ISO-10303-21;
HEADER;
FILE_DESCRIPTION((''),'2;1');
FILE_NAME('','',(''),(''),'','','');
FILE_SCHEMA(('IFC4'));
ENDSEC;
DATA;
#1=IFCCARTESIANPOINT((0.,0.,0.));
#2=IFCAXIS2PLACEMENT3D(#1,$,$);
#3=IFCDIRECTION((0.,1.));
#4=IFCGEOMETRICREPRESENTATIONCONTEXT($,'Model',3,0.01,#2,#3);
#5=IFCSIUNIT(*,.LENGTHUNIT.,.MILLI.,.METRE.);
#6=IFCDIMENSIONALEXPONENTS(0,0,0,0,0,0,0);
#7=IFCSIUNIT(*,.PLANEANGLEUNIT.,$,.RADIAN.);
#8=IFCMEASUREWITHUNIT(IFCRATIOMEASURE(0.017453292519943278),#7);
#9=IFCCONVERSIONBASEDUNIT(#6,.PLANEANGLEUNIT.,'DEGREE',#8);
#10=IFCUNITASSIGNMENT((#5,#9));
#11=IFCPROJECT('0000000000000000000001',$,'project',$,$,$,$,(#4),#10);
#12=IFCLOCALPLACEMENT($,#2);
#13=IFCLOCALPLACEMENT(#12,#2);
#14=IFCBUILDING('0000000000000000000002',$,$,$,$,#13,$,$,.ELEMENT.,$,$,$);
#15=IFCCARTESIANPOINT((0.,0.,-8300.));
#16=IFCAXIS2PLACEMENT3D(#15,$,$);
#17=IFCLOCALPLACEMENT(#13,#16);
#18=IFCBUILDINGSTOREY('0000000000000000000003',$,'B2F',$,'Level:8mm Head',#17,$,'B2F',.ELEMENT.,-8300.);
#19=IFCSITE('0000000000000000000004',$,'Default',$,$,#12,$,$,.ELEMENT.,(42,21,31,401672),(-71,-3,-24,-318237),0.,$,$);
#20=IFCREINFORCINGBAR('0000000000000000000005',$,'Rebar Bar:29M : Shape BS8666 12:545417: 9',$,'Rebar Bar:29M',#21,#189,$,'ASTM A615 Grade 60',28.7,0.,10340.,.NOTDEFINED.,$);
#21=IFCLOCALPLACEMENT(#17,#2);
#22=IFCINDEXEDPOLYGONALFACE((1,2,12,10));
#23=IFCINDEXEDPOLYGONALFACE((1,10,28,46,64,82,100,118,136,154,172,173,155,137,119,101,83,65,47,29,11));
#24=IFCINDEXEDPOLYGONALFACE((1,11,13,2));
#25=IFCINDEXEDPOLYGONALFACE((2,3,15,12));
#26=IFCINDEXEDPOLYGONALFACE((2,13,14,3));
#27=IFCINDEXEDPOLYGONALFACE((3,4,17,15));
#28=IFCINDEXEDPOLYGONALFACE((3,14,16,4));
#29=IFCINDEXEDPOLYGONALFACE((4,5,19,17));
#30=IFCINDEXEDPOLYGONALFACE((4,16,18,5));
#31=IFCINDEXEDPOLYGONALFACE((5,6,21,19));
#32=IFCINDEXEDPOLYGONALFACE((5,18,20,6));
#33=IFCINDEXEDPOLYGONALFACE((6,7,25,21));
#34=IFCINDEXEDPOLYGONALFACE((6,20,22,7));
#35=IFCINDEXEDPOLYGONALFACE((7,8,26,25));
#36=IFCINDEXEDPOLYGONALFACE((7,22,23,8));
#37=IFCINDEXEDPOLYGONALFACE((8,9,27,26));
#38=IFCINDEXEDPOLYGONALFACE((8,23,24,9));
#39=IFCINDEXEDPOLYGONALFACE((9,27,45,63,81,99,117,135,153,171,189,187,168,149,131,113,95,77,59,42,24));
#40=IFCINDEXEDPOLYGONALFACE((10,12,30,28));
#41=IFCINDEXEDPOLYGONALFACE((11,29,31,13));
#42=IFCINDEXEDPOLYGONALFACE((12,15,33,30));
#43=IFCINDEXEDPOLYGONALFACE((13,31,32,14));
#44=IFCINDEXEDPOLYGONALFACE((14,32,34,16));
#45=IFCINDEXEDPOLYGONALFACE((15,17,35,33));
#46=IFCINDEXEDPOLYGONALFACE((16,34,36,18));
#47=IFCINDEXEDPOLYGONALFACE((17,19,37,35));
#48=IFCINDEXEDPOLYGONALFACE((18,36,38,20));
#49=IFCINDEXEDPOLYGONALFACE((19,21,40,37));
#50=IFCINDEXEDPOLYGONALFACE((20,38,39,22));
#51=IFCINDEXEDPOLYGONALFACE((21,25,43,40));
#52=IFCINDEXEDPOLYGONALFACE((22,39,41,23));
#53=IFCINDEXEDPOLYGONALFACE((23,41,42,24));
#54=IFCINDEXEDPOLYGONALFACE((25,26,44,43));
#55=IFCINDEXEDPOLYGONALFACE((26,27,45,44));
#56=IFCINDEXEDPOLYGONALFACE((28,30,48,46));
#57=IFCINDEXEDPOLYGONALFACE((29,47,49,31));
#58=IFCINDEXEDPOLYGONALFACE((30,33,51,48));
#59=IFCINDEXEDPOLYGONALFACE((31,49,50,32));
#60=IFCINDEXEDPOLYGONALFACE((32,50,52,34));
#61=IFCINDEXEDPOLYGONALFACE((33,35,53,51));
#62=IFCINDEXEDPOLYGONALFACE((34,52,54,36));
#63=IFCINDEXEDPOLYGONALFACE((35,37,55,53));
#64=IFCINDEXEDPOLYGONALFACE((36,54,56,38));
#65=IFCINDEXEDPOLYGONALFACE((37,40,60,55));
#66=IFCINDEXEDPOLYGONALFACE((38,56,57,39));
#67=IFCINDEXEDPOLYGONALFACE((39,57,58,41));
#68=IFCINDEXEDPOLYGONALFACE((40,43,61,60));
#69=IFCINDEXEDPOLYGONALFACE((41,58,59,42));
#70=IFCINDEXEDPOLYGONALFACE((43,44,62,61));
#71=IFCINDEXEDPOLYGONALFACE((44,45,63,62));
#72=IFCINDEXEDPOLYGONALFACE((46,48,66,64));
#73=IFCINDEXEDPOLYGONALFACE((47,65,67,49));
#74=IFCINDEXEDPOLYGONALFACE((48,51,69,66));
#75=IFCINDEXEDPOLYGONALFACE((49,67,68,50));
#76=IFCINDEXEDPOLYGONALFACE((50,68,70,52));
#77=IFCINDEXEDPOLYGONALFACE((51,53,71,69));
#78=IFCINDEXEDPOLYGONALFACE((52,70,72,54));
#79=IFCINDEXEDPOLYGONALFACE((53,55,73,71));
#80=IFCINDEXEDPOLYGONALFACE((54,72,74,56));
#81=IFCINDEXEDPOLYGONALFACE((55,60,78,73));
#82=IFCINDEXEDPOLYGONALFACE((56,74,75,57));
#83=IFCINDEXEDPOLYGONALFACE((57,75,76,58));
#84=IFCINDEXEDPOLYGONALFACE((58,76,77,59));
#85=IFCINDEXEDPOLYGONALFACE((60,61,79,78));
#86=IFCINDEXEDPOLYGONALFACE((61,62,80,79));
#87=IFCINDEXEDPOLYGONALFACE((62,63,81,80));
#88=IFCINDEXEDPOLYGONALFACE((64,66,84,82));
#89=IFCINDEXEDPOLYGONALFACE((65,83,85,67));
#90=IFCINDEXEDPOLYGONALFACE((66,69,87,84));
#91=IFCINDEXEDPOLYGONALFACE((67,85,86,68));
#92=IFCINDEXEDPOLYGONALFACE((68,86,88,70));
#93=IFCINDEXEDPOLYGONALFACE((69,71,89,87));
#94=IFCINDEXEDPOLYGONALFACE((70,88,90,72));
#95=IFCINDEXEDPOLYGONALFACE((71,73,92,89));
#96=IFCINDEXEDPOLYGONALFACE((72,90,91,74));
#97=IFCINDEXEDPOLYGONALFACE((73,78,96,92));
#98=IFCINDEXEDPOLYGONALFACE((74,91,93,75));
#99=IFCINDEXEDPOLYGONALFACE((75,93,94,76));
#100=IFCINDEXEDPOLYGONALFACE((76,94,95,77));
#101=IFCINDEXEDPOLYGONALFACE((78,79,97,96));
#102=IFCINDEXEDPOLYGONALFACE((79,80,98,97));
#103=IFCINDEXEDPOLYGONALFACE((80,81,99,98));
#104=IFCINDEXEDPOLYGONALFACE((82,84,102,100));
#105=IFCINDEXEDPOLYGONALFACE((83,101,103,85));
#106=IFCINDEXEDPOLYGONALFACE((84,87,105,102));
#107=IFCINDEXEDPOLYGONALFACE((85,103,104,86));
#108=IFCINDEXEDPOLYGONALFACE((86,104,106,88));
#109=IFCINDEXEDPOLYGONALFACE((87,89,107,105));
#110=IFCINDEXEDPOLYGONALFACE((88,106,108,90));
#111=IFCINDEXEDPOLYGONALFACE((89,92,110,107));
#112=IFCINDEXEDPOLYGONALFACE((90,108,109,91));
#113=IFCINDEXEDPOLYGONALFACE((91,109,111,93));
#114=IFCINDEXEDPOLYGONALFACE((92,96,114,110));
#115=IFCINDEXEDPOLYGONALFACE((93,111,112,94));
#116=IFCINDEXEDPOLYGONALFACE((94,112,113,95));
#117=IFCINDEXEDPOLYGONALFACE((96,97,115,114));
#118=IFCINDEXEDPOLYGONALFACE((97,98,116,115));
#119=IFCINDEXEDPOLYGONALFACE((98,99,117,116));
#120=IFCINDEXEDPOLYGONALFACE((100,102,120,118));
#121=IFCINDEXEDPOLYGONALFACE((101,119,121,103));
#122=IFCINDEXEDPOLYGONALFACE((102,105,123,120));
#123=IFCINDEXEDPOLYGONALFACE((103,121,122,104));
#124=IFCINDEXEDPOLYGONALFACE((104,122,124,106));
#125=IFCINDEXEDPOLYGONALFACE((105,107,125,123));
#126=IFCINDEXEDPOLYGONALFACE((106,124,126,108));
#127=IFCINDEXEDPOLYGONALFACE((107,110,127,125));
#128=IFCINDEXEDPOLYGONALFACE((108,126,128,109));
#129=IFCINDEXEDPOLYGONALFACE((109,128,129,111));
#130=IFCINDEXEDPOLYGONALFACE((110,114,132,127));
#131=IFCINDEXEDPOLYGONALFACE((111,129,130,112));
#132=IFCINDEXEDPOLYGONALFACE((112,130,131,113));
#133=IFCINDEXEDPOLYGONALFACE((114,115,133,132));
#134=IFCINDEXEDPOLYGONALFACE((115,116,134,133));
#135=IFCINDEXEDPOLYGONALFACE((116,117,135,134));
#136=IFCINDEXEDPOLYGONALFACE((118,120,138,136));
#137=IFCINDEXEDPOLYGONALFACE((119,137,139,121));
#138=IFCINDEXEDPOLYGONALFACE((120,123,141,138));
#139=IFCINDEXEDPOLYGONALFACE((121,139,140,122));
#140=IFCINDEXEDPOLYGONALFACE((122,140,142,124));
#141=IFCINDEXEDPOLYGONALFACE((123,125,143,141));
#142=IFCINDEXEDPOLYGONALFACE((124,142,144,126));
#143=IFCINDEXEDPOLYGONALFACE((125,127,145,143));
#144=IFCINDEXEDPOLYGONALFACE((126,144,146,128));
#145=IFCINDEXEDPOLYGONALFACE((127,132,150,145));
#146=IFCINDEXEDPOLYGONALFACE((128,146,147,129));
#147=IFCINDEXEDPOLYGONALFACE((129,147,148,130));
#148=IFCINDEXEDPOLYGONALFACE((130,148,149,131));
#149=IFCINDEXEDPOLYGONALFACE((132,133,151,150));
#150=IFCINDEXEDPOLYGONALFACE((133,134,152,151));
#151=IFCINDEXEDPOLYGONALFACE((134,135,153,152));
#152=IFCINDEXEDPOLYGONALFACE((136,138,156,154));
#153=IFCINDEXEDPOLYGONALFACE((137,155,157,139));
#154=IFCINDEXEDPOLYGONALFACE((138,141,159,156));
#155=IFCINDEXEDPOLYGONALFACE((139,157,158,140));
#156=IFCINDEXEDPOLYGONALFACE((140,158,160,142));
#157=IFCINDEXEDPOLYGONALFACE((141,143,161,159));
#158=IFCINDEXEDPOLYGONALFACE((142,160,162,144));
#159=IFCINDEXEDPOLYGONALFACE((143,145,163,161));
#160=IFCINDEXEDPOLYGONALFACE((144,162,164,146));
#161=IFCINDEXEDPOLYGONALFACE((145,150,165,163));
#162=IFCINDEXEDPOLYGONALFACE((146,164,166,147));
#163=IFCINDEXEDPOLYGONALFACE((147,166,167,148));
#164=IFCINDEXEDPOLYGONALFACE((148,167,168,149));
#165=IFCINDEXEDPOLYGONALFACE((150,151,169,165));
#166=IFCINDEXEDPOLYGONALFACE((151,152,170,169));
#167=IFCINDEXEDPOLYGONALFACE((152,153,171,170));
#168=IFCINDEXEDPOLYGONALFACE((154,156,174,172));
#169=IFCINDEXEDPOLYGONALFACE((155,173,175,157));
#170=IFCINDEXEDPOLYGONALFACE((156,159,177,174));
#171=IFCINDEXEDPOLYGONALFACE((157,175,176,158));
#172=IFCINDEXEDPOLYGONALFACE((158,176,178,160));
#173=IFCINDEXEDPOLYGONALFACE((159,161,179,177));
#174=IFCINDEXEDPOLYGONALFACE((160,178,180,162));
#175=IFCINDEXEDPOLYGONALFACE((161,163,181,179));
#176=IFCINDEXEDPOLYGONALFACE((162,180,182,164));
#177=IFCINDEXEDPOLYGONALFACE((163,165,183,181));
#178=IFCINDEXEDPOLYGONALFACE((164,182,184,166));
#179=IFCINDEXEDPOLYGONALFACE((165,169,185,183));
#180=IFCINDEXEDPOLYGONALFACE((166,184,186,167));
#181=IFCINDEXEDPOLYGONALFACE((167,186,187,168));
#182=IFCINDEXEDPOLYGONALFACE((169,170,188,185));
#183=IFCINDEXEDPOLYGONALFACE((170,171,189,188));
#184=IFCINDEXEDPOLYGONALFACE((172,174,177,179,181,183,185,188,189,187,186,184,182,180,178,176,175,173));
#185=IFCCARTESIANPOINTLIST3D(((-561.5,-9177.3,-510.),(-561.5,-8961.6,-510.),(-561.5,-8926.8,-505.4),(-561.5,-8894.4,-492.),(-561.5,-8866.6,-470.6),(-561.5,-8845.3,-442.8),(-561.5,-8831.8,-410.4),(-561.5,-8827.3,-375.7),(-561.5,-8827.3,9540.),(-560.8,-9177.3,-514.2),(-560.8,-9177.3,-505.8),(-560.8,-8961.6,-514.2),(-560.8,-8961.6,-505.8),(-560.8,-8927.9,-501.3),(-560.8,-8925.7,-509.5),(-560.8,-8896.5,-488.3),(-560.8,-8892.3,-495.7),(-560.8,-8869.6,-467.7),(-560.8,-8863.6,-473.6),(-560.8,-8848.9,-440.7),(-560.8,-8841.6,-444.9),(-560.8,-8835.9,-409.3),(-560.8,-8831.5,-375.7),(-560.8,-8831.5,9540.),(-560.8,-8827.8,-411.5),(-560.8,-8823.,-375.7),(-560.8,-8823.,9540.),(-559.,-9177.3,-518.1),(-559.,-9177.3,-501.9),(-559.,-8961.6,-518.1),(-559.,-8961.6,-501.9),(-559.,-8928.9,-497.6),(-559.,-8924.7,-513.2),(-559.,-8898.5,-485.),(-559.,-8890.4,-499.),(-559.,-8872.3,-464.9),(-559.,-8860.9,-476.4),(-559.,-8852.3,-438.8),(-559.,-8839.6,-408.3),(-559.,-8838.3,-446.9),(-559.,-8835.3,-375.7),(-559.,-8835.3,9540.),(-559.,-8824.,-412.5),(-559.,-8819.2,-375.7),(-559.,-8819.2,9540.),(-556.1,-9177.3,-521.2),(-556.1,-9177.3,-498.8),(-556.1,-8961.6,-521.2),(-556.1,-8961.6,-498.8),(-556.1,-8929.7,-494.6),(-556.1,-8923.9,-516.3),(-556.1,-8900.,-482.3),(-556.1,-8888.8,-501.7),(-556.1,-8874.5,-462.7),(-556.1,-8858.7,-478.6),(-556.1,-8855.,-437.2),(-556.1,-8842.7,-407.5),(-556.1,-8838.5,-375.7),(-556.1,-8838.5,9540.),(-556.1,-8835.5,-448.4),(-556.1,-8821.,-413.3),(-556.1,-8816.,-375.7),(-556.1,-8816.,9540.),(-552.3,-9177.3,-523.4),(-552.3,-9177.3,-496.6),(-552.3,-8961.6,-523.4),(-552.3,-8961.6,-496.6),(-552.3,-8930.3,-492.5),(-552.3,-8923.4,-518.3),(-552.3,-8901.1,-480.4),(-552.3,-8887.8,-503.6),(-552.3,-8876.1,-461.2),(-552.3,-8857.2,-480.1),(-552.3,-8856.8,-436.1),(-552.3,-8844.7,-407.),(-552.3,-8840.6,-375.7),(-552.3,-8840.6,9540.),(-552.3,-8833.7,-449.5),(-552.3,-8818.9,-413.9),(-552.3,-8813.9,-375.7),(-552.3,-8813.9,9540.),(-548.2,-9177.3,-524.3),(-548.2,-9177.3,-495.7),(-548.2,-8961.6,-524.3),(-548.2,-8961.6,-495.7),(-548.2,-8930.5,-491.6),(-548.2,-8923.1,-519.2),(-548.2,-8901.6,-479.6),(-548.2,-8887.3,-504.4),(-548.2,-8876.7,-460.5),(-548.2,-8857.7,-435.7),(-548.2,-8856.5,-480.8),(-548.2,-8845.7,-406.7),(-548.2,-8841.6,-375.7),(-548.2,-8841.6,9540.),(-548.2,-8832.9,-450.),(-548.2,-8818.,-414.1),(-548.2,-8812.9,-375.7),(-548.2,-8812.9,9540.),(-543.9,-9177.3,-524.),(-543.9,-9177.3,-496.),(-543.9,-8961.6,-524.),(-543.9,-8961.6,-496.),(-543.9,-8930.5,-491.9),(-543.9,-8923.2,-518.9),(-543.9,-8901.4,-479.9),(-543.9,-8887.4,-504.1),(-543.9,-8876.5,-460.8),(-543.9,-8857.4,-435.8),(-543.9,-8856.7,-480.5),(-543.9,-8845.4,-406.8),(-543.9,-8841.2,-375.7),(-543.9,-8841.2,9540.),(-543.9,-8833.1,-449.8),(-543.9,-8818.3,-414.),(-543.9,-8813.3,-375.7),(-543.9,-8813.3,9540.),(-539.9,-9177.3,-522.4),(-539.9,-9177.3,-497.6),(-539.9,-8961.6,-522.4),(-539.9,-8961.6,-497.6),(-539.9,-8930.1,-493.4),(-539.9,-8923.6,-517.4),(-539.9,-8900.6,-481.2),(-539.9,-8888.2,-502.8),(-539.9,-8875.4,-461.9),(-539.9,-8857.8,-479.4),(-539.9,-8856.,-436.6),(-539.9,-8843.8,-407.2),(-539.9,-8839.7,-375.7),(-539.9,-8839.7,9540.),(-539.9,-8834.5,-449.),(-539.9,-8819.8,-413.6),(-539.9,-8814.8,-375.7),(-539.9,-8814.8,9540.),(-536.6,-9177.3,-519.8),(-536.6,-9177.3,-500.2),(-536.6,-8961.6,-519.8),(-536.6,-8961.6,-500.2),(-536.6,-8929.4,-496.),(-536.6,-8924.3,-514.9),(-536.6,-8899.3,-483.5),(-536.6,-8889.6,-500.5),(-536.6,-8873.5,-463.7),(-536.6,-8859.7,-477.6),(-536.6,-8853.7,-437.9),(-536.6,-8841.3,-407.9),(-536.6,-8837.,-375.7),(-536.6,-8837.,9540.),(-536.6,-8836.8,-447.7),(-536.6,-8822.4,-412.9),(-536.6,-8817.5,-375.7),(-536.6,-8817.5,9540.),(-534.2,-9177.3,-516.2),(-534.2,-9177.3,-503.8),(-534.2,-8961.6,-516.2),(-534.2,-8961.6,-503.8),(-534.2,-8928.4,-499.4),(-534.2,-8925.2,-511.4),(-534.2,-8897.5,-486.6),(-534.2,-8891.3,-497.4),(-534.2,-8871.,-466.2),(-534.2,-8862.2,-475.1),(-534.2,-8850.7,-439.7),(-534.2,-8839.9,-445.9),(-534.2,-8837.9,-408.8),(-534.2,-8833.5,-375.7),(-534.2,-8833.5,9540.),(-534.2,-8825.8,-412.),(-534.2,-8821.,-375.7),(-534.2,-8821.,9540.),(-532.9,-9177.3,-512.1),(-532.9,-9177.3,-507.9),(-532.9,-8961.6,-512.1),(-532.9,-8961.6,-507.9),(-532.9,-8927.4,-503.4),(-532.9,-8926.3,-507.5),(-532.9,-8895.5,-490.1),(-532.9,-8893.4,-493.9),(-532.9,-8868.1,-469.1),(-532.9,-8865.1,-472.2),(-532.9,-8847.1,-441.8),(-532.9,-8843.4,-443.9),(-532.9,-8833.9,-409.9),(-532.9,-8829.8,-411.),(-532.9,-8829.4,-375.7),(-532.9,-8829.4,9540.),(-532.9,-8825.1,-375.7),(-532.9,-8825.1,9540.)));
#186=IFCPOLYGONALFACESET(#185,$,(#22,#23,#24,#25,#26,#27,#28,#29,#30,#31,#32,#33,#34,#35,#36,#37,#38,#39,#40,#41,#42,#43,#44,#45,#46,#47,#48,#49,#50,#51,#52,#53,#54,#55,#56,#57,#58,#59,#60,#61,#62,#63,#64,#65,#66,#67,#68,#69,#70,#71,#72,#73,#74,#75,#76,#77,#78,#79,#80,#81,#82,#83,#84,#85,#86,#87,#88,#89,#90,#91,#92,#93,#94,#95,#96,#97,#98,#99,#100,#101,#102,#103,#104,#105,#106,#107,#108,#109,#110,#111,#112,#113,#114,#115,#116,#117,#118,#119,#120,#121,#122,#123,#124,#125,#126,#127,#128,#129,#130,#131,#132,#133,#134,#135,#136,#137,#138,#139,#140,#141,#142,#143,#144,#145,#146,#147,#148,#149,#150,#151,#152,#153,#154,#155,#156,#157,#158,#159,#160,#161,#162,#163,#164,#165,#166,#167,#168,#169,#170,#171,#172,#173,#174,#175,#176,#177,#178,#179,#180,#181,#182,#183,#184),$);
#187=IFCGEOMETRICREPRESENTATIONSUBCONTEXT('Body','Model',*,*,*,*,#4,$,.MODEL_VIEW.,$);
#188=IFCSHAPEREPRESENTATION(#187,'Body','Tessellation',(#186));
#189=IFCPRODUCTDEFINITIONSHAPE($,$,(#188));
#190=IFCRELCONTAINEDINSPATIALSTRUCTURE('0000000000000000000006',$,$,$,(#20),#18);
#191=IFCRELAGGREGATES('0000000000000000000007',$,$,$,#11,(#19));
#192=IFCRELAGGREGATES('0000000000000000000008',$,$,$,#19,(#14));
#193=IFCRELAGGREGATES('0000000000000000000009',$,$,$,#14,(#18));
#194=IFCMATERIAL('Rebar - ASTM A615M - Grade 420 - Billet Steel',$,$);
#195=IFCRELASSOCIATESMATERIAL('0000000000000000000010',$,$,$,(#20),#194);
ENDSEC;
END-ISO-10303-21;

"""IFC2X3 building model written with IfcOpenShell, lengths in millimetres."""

from ifc_helpers import new_model, entity, si_unit, converted_unit, direction, frame, origin, place, context, subcontext, project, spatial, material, element, save


model = new_model("IFC2X3")

# Units and contexts
model_context = context("Model", 3, precision=0.01, world=origin(), true_north=direction((0.0, 1.0)))
body_context = subcontext(model_context, "Body", "Model", "MODEL_VIEW")
ifc_project = project(units=[si_unit("LENGTHUNIT", "METRE", prefix="MILLI"), converted_unit("PLANEANGLEUNIT", "DEGREE", entity("IfcRatioMeasure", 0.017453292519943278), si_unit("PLANEANGLEUNIT", "RADIAN"), dimensions=[0, 0, 0, 0, 0, 0, 0])], contexts=[model_context])

# Site, building, storey
site_placement = place(None, origin())
site = spatial("IfcSite", under=ifc_project, at=site_placement, Name="Default", CompositionType="ELEMENT", RefLatitude=(42, 21, 31, 401672), RefLongitude=(-71, -3, -24, -318237), RefElevation=0.0)
building_placement = place(site_placement, origin())
building = spatial("IfcBuilding", under=site, at=building_placement, CompositionType="ELEMENT")
storey_placement = place(building_placement, frame((0.0, 0.0, -8300.0)))
storey = spatial("IfcBuildingStorey", under=building, at=storey_placement, Name="B2F", ObjectType="Level:8mm Head", LongName="B2F", CompositionType="ELEMENT", Elevation=-8300.0)

# Reinforcing bar
ifc_material_1 = material(Name="Rebar - ASTM A615M - Grade 420 - Billet Steel")
reinforcing_bar_1_placement = place(storey_placement, origin())
element("IfcReinforcingBar", 1, at=reinforcing_bar_1_placement, inside=storey, material=ifc_material_1, Name="Rebar Bar:29M : Shape BS8666 12:545417: 9", SteelGrade="ASTM A615 Grade 60", ObjectType="Rebar Bar:29M", BarLength=10340.0, BarRole="NOTDEFINED", CrossSectionArea=0.0, NominalDiameter=28.7, context=body_context, shape_type="AdvancedSweptSolid", body=[
    entity("IfcSweptDiskSolid", entity("IfcCompositeCurve", [entity("IfcCompositeCurveSegment", "CONTINUOUS", True, entity("IfcPolyline", [entity("IfcCartesianPoint", [-547.1, -8827.3, 9540.0]), entity("IfcCartesianPoint", [-547.1, -8827.3, -375.7])])), entity("IfcCompositeCurveSegment", "CONTINUOUS", True, entity("IfcTrimmedCurve", entity("IfcCircle", entity("IfcAxis2Placement3D", entity("IfcCartesianPoint", [-547.1, -8961.6, -375.7]), entity("IfcDirection", [-1.0, 0.0, 0.0]), entity("IfcDirection", [0.0, 0.0, -1.0])), 134.3), [entity("IfcParameterValue", 270.0)], [entity("IfcParameterValue", 360.0)], True, "PARAMETER")), entity("IfcCompositeCurveSegment", "CONTINUOUS", True, entity("IfcPolyline", [entity("IfcCartesianPoint", [-547.1, -8961.6, -510.0]), entity("IfcCartesianPoint", [-547.1, -9177.3, -510.0])]))], False), 14.3, None, 0.0, 92.0),
])

save(model, "model.ifc")
